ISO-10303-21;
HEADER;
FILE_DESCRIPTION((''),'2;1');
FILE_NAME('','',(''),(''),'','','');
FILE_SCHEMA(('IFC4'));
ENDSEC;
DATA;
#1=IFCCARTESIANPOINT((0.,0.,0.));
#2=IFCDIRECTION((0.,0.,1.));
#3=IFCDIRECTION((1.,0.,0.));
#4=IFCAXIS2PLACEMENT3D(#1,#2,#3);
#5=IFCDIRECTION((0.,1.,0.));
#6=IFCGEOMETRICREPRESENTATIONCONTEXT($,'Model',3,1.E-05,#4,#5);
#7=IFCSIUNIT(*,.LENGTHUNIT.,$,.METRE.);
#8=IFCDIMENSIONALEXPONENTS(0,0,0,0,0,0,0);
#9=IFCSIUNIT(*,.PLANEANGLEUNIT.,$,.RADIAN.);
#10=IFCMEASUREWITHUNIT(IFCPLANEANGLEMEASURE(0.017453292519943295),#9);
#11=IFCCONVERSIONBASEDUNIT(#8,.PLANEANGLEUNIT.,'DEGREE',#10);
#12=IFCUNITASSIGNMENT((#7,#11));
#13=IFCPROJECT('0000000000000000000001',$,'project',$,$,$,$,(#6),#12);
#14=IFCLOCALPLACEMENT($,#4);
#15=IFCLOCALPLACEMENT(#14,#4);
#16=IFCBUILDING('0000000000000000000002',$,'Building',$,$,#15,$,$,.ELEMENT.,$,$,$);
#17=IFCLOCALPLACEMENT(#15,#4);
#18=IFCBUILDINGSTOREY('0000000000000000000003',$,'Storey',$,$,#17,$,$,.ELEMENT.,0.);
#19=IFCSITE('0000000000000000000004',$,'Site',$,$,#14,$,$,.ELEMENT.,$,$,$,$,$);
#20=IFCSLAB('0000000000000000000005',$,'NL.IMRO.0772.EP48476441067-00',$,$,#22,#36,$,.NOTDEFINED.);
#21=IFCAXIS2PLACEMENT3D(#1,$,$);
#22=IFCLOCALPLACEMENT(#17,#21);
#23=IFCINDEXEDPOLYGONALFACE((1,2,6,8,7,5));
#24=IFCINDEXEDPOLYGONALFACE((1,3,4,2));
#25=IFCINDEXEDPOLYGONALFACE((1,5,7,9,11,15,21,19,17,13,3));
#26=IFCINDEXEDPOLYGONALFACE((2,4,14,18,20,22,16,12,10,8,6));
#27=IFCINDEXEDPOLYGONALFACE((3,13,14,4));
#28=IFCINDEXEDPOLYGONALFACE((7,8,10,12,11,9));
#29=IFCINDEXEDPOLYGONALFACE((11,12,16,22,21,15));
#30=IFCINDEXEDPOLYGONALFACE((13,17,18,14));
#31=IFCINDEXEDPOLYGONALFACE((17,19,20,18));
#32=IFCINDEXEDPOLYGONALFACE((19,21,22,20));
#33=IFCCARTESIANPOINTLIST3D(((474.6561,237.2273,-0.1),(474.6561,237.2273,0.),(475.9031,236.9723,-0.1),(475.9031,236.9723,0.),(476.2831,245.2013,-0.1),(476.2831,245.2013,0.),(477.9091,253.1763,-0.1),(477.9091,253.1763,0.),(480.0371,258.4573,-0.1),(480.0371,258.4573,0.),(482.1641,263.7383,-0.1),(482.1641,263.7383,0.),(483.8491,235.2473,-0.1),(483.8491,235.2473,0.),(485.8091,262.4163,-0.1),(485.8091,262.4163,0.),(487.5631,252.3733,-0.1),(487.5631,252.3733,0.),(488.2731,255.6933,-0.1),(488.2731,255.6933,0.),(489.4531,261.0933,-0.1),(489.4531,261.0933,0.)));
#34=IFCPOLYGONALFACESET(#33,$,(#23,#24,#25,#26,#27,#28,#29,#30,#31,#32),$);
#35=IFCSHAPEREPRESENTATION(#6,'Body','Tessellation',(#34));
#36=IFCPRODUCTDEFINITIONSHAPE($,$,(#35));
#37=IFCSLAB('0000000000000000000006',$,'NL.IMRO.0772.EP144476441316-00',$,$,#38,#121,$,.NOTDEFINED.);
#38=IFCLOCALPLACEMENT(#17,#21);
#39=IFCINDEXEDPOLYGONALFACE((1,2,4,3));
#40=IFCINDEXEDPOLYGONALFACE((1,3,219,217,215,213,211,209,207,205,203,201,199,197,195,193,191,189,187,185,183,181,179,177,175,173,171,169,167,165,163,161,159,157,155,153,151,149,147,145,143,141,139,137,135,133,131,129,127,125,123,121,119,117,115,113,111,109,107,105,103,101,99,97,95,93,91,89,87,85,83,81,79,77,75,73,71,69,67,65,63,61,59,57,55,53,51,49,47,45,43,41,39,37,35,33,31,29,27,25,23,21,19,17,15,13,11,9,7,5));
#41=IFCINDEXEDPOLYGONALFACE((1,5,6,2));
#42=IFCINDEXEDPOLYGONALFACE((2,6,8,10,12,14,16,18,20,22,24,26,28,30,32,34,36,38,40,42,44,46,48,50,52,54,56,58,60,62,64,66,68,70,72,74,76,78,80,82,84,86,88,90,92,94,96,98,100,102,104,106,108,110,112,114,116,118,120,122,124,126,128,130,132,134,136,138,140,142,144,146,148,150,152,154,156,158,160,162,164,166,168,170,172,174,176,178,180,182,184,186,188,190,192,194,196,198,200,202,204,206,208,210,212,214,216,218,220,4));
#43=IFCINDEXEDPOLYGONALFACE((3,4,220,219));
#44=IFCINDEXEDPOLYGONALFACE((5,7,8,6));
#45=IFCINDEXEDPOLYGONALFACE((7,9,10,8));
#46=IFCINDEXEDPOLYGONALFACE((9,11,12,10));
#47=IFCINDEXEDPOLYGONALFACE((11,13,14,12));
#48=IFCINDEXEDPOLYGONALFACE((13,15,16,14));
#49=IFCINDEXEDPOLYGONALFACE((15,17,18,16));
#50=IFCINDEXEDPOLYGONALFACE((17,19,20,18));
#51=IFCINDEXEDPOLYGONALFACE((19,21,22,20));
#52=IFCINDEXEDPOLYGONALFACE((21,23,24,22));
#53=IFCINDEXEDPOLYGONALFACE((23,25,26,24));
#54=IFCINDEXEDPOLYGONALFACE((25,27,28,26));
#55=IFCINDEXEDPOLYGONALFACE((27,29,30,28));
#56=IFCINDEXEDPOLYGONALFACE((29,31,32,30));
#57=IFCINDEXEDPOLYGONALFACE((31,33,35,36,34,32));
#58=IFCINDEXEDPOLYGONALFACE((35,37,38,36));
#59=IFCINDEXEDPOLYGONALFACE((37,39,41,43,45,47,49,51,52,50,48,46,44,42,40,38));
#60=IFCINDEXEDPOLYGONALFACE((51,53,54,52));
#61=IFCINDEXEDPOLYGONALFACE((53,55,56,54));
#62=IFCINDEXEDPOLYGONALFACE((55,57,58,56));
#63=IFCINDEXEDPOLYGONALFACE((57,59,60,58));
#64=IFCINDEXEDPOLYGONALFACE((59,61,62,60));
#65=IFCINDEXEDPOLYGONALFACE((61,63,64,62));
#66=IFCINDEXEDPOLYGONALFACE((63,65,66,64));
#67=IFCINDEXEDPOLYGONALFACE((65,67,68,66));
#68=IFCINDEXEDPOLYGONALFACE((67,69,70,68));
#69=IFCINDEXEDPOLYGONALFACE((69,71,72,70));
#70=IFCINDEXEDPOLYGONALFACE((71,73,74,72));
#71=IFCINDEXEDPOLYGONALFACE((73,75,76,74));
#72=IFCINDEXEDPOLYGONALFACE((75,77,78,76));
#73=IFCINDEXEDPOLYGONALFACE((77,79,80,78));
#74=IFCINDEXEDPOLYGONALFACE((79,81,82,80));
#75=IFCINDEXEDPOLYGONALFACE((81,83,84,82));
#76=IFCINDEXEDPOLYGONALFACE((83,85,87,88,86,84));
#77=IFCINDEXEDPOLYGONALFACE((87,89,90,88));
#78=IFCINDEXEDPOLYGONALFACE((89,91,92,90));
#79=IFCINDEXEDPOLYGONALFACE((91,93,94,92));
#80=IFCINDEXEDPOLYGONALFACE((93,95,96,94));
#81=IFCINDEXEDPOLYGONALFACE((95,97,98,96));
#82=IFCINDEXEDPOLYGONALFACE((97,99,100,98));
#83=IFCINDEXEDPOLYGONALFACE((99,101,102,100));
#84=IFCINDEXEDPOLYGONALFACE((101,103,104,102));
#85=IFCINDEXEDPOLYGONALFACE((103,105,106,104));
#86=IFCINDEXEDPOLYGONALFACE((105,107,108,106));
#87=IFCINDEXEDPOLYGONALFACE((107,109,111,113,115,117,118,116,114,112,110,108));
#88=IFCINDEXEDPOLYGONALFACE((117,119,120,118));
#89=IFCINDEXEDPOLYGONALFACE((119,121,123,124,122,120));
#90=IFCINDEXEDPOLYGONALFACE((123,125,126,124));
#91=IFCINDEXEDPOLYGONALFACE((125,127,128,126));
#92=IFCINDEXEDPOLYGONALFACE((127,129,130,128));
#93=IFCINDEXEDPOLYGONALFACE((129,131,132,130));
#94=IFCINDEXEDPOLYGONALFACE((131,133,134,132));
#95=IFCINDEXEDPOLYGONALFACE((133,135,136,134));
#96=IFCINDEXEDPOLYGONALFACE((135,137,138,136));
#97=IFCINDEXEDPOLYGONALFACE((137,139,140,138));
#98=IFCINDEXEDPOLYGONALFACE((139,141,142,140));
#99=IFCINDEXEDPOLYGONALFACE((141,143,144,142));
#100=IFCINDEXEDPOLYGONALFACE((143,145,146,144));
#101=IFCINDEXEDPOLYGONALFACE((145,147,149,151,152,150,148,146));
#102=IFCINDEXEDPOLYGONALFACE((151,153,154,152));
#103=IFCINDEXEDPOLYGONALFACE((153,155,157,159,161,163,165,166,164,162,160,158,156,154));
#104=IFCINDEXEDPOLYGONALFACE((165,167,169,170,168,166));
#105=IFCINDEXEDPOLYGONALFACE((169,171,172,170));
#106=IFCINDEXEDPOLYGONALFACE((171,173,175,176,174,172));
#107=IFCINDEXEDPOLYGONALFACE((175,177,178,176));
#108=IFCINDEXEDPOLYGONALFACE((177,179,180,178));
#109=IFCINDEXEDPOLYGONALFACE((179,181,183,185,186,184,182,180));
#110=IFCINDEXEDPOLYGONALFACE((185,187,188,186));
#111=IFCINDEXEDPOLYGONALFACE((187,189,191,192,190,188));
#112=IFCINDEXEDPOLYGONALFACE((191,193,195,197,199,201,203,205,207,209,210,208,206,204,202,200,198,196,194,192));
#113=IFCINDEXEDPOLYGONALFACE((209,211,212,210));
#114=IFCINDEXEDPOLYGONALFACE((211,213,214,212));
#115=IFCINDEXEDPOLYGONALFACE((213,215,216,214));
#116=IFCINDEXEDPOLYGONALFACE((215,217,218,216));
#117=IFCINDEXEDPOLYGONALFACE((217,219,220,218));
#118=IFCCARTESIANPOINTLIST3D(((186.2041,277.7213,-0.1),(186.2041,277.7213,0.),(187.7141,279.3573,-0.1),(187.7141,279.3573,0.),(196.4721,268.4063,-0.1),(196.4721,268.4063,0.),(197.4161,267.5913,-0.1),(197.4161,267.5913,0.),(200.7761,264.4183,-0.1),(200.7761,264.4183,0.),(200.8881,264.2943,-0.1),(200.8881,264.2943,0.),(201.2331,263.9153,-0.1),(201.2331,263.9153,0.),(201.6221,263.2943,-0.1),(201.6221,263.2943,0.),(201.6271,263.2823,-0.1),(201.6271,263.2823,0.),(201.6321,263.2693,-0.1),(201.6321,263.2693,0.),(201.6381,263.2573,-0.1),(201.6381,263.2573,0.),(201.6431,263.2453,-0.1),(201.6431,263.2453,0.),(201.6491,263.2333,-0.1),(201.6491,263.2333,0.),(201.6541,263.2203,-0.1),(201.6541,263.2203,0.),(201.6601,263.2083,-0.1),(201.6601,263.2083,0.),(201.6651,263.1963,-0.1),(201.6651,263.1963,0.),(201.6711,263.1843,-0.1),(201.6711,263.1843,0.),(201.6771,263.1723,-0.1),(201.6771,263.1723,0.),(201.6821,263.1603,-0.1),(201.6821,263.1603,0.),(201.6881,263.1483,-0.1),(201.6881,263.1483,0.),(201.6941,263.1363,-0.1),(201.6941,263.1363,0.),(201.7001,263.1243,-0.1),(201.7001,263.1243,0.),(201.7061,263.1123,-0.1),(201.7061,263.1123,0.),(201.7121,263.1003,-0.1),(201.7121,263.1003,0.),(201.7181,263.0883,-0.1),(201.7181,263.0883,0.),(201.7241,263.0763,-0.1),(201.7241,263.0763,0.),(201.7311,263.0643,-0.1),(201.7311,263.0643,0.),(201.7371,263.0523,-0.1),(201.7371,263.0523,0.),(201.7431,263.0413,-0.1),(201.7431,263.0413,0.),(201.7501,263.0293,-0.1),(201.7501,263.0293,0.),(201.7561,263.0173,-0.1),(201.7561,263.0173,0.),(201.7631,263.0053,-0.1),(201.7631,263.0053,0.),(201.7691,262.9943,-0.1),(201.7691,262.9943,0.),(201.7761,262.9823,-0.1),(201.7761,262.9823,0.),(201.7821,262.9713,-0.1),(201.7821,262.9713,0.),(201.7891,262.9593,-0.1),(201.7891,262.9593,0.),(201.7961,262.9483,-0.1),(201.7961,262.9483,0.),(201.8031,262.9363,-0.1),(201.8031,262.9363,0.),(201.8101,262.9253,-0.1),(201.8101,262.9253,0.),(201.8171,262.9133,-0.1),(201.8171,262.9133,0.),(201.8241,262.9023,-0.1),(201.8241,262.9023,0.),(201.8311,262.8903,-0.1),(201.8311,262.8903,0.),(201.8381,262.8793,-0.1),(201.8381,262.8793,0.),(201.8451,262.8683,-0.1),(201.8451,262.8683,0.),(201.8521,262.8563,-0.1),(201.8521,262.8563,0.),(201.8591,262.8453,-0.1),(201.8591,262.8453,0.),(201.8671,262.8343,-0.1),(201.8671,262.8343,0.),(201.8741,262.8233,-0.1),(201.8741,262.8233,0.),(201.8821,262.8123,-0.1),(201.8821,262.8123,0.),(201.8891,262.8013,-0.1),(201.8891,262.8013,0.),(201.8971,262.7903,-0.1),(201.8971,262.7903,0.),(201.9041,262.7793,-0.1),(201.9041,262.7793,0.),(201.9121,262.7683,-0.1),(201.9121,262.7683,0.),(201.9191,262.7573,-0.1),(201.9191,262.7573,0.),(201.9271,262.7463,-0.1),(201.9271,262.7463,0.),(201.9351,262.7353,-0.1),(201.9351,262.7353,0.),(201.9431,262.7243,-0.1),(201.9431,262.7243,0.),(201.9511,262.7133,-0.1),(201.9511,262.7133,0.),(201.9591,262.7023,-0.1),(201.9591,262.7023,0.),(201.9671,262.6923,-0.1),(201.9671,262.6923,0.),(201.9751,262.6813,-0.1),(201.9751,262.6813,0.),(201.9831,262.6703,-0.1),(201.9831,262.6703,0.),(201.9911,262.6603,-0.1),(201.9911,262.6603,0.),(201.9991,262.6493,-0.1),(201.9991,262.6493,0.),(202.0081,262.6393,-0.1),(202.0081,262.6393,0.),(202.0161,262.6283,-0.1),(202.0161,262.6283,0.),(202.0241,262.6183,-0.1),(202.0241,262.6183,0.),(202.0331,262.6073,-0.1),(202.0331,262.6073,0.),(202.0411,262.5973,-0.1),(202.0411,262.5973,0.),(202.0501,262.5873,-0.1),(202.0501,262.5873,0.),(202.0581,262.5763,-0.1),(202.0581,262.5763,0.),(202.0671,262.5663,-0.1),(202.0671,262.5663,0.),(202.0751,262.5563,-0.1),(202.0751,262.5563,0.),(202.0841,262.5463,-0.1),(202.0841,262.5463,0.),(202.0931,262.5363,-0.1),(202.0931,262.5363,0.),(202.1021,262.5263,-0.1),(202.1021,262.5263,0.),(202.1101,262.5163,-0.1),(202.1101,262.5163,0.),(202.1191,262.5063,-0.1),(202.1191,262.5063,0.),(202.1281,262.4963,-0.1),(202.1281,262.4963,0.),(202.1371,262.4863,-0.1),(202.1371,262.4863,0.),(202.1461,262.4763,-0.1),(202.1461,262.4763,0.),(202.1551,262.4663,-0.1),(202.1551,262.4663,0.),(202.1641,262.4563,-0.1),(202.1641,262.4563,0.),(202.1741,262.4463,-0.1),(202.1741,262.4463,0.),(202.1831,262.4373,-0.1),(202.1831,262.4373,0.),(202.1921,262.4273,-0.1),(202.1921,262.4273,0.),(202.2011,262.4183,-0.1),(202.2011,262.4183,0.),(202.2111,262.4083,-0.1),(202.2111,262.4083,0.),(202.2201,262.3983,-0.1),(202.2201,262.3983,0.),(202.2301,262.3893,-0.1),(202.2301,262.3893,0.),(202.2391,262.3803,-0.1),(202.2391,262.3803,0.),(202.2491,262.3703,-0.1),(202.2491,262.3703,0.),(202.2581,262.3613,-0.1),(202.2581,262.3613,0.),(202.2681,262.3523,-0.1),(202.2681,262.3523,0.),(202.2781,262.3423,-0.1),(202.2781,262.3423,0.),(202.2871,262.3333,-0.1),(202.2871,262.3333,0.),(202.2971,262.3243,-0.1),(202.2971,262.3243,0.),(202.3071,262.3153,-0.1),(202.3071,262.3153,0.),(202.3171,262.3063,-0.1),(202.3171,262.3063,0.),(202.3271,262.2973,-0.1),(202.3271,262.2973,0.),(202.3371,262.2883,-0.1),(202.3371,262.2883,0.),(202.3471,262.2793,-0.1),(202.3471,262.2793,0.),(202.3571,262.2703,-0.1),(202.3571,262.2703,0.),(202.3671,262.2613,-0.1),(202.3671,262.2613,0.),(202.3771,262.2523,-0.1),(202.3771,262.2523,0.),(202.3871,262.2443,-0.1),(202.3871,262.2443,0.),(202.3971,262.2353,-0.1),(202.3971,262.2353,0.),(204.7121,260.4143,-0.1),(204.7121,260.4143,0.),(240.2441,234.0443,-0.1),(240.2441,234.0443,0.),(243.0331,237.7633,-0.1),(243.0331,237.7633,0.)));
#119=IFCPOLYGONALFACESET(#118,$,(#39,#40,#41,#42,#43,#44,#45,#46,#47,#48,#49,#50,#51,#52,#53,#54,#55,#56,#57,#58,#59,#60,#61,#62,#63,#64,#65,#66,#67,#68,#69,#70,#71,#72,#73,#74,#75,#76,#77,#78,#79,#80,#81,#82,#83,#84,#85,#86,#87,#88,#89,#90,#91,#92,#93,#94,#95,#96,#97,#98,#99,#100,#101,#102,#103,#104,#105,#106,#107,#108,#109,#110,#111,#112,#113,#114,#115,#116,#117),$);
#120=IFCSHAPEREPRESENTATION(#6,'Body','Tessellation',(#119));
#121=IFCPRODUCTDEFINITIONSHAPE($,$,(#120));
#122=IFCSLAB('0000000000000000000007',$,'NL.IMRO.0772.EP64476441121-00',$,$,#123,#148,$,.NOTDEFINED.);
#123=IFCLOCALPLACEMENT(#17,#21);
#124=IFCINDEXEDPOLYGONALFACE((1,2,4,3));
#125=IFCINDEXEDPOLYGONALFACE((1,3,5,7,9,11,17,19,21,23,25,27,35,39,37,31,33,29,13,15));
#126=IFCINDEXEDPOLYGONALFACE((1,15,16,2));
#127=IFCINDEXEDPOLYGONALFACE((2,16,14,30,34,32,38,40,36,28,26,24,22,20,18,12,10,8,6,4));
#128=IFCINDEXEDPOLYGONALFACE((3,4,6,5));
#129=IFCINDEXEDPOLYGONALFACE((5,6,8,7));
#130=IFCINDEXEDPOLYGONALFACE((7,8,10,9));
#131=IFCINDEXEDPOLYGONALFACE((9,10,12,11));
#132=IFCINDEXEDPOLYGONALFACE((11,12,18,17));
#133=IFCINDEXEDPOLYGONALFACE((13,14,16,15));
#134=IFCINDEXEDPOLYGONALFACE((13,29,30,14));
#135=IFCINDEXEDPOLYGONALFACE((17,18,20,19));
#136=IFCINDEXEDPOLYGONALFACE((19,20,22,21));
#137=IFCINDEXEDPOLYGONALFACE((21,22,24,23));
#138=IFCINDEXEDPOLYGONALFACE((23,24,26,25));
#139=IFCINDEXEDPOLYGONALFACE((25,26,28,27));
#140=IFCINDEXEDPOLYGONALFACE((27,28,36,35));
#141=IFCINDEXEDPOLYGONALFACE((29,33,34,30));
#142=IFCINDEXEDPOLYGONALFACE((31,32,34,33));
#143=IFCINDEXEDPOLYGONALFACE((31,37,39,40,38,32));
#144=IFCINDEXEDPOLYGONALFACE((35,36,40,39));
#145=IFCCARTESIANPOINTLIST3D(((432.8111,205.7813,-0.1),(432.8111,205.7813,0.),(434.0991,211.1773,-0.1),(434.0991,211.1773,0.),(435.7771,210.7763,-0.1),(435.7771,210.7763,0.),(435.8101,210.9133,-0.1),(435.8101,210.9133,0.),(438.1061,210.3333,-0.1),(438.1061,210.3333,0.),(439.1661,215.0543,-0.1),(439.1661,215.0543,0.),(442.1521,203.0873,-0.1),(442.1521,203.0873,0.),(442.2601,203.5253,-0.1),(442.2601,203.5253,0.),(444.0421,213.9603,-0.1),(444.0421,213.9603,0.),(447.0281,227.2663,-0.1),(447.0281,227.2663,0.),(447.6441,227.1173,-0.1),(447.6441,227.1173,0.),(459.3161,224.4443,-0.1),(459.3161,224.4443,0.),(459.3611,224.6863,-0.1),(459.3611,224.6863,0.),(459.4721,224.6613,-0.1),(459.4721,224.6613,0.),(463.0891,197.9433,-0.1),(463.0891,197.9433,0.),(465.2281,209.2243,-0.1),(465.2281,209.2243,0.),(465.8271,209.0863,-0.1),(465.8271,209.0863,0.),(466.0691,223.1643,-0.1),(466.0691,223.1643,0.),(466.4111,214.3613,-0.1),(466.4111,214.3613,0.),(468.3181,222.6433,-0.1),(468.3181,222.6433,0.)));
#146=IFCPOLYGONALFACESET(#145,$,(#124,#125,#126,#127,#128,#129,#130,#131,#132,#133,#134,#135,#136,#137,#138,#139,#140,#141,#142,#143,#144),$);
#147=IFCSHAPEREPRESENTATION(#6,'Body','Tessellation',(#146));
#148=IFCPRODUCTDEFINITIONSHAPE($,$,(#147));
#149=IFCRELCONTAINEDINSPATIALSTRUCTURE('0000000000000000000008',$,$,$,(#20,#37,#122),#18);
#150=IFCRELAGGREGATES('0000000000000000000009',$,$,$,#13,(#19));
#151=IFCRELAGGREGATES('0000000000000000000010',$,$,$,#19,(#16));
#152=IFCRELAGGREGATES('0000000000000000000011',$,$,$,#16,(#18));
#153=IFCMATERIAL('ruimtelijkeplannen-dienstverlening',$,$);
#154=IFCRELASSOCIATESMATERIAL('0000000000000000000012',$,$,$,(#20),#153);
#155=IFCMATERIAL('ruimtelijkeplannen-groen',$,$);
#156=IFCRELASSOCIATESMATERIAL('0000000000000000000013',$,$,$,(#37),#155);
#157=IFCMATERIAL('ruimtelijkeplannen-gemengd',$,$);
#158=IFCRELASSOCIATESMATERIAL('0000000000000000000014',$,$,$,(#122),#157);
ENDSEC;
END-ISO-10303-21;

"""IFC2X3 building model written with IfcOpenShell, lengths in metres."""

from ifc_helpers import new_model, entity, si_unit, converted_unit, direction, frame, origin_with_axes, place, context, project, spatial, polyline, outline, extrude, material, element, save


model = new_model("IFC2X3")

# Units and contexts
model_context = context("Model", 3, precision=1e-05, world=origin_with_axes(), true_north=direction((0.0, 1.0, 0.0)))
ifc_project = project(units=[si_unit("LENGTHUNIT", "METRE"), converted_unit("PLANEANGLEUNIT", "DEGREE", entity("IfcPlaneAngleMeasure", 0.017453292519943295), si_unit("PLANEANGLEUNIT", "RADIAN"), dimensions=[0, 0, 0, 0, 0, 0, 0])], contexts=[model_context])

# Site, building, storey
site_placement = place(None, origin_with_axes())
site = spatial("IfcSite", under=ifc_project, at=site_placement, Name="Site", CompositionType="ELEMENT")
building_placement = place(site_placement, origin_with_axes())
building = spatial("IfcBuilding", under=site, at=building_placement, Name="Building", CompositionType="ELEMENT")
storey_placement = place(building_placement, origin_with_axes())
storey = spatial("IfcBuildingStorey", under=building, at=storey_placement, Name="Storey", CompositionType="ELEMENT", Elevation=0.0)

# Slabs
ifc_material_1 = material(Name="ruimtelijkeplannen-dienstverlening")
slab_1_placement = place(storey_placement, frame((0.0, 0.0, -0.1), z_axis=(0.0, 0.0, 1.0), x_axis=(1.0, 0.0, 0.0)))
element("IfcSlab", 1, at=slab_1_placement, inside=storey, material=ifc_material_1, Name="NL.IMRO.0772.EP48476441067-00", PredefinedType="NOTDEFINED", context=model_context, shape_type="SweptSolid", body=[
    extrude(outline(polyline([(475.9031, 236.9723), (474.6561, 237.2273), (476.2831, 245.2013), (477.9091, 253.1763), (480.0371, 258.4573), (482.1641, 263.7383), (485.8091, 262.4163), (489.4531, 261.0933), (488.2731, 255.6933), (487.5631, 252.3733), (483.8491, 235.2473), (475.9031, 236.9723)])), origin_with_axes(), (0.0, 0.0, 1.0), 0.1),
])
ifc_material_2 = material(Name="ruimtelijkeplannen-groen")
slab_2_placement = place(storey_placement, frame((0.0, 0.0, -0.1), z_axis=(0.0, 0.0, 1.0), x_axis=(1.0, 0.0, 0.0)))
element("IfcSlab", 2, at=slab_2_placement, inside=storey, material=ifc_material_2, Name="NL.IMRO.0772.EP144476441316-00", PredefinedType="NOTDEFINED", context=model_context, shape_type="SweptSolid", body=[
    extrude(outline(polyline([(201.2331, 263.9153), (200.8881, 264.2943), (200.7761, 264.4183), (197.4161, 267.5913), (196.4721, 268.4063), (186.2041, 277.7213), (187.7141, 279.3573), (243.0331, 237.7633), (240.2441, 234.0443), (204.7121, 260.4143), (202.3971, 262.2353), (202.3871, 262.2443), (202.3771, 262.2523), (202.3671, 262.2613), (202.3571, 262.2703), (202.3471, 262.2793), (202.3371, 262.2883), (202.3271, 262.2973), (202.3171, 262.3063), (202.3071, 262.3153), (202.2971, 262.3243), (202.2871, 262.3333), (202.2781, 262.3423), (202.2681, 262.3523), (202.2581, 262.3613), (202.2491, 262.3703), (202.2391, 262.3803), (202.2301, 262.3893), (202.2201, 262.3983), (202.2111, 262.4083), (202.2011, 262.4183), (202.1921, 262.4273), (202.1831, 262.4373), (202.1741, 262.4463), (202.1641, 262.4563), (202.1551, 262.4663), (202.1461, 262.4763), (202.1371, 262.4863), (202.1281, 262.4963), (202.1191, 262.5063), (202.1101, 262.5163), (202.1021, 262.5263), (202.0931, 262.5363), (202.0841, 262.5463), (202.0751, 262.5563), (202.0671, 262.5663), (202.0581, 262.5763), (202.0501, 262.5873), (202.0411, 262.5973), (202.0331, 262.6073), (202.0241, 262.6183), (202.0161, 262.6283), (202.0081, 262.6393), (201.9991, 262.6493), (201.9911, 262.6603), (201.9831, 262.6703), (201.9751, 262.6813), (201.9671, 262.6923), (201.9591, 262.7023), (201.9511, 262.7133), (201.9431, 262.7243), (201.9351, 262.7353), (201.9271, 262.7463), (201.9191, 262.7573), (201.9121, 262.7683), (201.9041, 262.7793), (201.8971, 262.7903), (201.8891, 262.8013), (201.8821, 262.8123), (201.8741, 262.8233), (201.8671, 262.8343), (201.8591, 262.8453), (201.8521, 262.8563), (201.8451, 262.8683), (201.8381, 262.8793), (201.8311, 262.8903), (201.8241, 262.9023), (201.8171, 262.9133), (201.8101, 262.9253), (201.8031, 262.9363), (201.7961, 262.9483), (201.7891, 262.9593), (201.7821, 262.9713), (201.7761, 262.9823), (201.7691, 262.9943), (201.7631, 263.0053), (201.7561, 263.0173), (201.7501, 263.0293), (201.7431, 263.0413), (201.7371, 263.0523), (201.7311, 263.0643), (201.7241, 263.0763), (201.7181, 263.0883), (201.7121, 263.1003), (201.7061, 263.1123), (201.7001, 263.1243), (201.6941, 263.1363), (201.6881, 263.1483), (201.6821, 263.1603), (201.6771, 263.1723), (201.6711, 263.1843), (201.6651, 263.1963), (201.6601, 263.2083), (201.6541, 263.2203), (201.6491, 263.2333), (201.6431, 263.2453), (201.6381, 263.2573), (201.6321, 263.2693), (201.6271, 263.2823), (201.6221, 263.2943), (201.2331, 263.9153)])), origin_with_axes(), (0.0, 0.0, 1.0), 0.1),
])
ifc_material_3 = material(Name="ruimtelijkeplannen-gemengd")
slab_3_placement = place(storey_placement, frame((0.0, 0.0, -0.1), z_axis=(0.0, 0.0, 1.0), x_axis=(1.0, 0.0, 0.0)))
element("IfcSlab", 3, at=slab_3_placement, inside=storey, material=ifc_material_3, Name="NL.IMRO.0772.EP64476441121-00", PredefinedType="NOTDEFINED", context=model_context, shape_type="SweptSolid", body=[
    extrude(outline(polyline([(447.6441, 227.1173), (459.3161, 224.4443), (459.3611, 224.6863), (459.4721, 224.6613), (466.0691, 223.1643), (468.3181, 222.6433), (466.4111, 214.3613), (465.2281, 209.2243), (465.8271, 209.0863), (463.0891, 197.9433), (442.1521, 203.0873), (442.2601, 203.5253), (432.8111, 205.7813), (434.0991, 211.1773), (435.7771, 210.7763), (435.8101, 210.9133), (438.1061, 210.3333), (439.1661, 215.0543), (444.0421, 213.9603), (447.0281, 227.2663), (447.6441, 227.1173)])), origin_with_axes(), (0.0, 0.0, 1.0), 0.1),
])

save(model, "model.ifc")
